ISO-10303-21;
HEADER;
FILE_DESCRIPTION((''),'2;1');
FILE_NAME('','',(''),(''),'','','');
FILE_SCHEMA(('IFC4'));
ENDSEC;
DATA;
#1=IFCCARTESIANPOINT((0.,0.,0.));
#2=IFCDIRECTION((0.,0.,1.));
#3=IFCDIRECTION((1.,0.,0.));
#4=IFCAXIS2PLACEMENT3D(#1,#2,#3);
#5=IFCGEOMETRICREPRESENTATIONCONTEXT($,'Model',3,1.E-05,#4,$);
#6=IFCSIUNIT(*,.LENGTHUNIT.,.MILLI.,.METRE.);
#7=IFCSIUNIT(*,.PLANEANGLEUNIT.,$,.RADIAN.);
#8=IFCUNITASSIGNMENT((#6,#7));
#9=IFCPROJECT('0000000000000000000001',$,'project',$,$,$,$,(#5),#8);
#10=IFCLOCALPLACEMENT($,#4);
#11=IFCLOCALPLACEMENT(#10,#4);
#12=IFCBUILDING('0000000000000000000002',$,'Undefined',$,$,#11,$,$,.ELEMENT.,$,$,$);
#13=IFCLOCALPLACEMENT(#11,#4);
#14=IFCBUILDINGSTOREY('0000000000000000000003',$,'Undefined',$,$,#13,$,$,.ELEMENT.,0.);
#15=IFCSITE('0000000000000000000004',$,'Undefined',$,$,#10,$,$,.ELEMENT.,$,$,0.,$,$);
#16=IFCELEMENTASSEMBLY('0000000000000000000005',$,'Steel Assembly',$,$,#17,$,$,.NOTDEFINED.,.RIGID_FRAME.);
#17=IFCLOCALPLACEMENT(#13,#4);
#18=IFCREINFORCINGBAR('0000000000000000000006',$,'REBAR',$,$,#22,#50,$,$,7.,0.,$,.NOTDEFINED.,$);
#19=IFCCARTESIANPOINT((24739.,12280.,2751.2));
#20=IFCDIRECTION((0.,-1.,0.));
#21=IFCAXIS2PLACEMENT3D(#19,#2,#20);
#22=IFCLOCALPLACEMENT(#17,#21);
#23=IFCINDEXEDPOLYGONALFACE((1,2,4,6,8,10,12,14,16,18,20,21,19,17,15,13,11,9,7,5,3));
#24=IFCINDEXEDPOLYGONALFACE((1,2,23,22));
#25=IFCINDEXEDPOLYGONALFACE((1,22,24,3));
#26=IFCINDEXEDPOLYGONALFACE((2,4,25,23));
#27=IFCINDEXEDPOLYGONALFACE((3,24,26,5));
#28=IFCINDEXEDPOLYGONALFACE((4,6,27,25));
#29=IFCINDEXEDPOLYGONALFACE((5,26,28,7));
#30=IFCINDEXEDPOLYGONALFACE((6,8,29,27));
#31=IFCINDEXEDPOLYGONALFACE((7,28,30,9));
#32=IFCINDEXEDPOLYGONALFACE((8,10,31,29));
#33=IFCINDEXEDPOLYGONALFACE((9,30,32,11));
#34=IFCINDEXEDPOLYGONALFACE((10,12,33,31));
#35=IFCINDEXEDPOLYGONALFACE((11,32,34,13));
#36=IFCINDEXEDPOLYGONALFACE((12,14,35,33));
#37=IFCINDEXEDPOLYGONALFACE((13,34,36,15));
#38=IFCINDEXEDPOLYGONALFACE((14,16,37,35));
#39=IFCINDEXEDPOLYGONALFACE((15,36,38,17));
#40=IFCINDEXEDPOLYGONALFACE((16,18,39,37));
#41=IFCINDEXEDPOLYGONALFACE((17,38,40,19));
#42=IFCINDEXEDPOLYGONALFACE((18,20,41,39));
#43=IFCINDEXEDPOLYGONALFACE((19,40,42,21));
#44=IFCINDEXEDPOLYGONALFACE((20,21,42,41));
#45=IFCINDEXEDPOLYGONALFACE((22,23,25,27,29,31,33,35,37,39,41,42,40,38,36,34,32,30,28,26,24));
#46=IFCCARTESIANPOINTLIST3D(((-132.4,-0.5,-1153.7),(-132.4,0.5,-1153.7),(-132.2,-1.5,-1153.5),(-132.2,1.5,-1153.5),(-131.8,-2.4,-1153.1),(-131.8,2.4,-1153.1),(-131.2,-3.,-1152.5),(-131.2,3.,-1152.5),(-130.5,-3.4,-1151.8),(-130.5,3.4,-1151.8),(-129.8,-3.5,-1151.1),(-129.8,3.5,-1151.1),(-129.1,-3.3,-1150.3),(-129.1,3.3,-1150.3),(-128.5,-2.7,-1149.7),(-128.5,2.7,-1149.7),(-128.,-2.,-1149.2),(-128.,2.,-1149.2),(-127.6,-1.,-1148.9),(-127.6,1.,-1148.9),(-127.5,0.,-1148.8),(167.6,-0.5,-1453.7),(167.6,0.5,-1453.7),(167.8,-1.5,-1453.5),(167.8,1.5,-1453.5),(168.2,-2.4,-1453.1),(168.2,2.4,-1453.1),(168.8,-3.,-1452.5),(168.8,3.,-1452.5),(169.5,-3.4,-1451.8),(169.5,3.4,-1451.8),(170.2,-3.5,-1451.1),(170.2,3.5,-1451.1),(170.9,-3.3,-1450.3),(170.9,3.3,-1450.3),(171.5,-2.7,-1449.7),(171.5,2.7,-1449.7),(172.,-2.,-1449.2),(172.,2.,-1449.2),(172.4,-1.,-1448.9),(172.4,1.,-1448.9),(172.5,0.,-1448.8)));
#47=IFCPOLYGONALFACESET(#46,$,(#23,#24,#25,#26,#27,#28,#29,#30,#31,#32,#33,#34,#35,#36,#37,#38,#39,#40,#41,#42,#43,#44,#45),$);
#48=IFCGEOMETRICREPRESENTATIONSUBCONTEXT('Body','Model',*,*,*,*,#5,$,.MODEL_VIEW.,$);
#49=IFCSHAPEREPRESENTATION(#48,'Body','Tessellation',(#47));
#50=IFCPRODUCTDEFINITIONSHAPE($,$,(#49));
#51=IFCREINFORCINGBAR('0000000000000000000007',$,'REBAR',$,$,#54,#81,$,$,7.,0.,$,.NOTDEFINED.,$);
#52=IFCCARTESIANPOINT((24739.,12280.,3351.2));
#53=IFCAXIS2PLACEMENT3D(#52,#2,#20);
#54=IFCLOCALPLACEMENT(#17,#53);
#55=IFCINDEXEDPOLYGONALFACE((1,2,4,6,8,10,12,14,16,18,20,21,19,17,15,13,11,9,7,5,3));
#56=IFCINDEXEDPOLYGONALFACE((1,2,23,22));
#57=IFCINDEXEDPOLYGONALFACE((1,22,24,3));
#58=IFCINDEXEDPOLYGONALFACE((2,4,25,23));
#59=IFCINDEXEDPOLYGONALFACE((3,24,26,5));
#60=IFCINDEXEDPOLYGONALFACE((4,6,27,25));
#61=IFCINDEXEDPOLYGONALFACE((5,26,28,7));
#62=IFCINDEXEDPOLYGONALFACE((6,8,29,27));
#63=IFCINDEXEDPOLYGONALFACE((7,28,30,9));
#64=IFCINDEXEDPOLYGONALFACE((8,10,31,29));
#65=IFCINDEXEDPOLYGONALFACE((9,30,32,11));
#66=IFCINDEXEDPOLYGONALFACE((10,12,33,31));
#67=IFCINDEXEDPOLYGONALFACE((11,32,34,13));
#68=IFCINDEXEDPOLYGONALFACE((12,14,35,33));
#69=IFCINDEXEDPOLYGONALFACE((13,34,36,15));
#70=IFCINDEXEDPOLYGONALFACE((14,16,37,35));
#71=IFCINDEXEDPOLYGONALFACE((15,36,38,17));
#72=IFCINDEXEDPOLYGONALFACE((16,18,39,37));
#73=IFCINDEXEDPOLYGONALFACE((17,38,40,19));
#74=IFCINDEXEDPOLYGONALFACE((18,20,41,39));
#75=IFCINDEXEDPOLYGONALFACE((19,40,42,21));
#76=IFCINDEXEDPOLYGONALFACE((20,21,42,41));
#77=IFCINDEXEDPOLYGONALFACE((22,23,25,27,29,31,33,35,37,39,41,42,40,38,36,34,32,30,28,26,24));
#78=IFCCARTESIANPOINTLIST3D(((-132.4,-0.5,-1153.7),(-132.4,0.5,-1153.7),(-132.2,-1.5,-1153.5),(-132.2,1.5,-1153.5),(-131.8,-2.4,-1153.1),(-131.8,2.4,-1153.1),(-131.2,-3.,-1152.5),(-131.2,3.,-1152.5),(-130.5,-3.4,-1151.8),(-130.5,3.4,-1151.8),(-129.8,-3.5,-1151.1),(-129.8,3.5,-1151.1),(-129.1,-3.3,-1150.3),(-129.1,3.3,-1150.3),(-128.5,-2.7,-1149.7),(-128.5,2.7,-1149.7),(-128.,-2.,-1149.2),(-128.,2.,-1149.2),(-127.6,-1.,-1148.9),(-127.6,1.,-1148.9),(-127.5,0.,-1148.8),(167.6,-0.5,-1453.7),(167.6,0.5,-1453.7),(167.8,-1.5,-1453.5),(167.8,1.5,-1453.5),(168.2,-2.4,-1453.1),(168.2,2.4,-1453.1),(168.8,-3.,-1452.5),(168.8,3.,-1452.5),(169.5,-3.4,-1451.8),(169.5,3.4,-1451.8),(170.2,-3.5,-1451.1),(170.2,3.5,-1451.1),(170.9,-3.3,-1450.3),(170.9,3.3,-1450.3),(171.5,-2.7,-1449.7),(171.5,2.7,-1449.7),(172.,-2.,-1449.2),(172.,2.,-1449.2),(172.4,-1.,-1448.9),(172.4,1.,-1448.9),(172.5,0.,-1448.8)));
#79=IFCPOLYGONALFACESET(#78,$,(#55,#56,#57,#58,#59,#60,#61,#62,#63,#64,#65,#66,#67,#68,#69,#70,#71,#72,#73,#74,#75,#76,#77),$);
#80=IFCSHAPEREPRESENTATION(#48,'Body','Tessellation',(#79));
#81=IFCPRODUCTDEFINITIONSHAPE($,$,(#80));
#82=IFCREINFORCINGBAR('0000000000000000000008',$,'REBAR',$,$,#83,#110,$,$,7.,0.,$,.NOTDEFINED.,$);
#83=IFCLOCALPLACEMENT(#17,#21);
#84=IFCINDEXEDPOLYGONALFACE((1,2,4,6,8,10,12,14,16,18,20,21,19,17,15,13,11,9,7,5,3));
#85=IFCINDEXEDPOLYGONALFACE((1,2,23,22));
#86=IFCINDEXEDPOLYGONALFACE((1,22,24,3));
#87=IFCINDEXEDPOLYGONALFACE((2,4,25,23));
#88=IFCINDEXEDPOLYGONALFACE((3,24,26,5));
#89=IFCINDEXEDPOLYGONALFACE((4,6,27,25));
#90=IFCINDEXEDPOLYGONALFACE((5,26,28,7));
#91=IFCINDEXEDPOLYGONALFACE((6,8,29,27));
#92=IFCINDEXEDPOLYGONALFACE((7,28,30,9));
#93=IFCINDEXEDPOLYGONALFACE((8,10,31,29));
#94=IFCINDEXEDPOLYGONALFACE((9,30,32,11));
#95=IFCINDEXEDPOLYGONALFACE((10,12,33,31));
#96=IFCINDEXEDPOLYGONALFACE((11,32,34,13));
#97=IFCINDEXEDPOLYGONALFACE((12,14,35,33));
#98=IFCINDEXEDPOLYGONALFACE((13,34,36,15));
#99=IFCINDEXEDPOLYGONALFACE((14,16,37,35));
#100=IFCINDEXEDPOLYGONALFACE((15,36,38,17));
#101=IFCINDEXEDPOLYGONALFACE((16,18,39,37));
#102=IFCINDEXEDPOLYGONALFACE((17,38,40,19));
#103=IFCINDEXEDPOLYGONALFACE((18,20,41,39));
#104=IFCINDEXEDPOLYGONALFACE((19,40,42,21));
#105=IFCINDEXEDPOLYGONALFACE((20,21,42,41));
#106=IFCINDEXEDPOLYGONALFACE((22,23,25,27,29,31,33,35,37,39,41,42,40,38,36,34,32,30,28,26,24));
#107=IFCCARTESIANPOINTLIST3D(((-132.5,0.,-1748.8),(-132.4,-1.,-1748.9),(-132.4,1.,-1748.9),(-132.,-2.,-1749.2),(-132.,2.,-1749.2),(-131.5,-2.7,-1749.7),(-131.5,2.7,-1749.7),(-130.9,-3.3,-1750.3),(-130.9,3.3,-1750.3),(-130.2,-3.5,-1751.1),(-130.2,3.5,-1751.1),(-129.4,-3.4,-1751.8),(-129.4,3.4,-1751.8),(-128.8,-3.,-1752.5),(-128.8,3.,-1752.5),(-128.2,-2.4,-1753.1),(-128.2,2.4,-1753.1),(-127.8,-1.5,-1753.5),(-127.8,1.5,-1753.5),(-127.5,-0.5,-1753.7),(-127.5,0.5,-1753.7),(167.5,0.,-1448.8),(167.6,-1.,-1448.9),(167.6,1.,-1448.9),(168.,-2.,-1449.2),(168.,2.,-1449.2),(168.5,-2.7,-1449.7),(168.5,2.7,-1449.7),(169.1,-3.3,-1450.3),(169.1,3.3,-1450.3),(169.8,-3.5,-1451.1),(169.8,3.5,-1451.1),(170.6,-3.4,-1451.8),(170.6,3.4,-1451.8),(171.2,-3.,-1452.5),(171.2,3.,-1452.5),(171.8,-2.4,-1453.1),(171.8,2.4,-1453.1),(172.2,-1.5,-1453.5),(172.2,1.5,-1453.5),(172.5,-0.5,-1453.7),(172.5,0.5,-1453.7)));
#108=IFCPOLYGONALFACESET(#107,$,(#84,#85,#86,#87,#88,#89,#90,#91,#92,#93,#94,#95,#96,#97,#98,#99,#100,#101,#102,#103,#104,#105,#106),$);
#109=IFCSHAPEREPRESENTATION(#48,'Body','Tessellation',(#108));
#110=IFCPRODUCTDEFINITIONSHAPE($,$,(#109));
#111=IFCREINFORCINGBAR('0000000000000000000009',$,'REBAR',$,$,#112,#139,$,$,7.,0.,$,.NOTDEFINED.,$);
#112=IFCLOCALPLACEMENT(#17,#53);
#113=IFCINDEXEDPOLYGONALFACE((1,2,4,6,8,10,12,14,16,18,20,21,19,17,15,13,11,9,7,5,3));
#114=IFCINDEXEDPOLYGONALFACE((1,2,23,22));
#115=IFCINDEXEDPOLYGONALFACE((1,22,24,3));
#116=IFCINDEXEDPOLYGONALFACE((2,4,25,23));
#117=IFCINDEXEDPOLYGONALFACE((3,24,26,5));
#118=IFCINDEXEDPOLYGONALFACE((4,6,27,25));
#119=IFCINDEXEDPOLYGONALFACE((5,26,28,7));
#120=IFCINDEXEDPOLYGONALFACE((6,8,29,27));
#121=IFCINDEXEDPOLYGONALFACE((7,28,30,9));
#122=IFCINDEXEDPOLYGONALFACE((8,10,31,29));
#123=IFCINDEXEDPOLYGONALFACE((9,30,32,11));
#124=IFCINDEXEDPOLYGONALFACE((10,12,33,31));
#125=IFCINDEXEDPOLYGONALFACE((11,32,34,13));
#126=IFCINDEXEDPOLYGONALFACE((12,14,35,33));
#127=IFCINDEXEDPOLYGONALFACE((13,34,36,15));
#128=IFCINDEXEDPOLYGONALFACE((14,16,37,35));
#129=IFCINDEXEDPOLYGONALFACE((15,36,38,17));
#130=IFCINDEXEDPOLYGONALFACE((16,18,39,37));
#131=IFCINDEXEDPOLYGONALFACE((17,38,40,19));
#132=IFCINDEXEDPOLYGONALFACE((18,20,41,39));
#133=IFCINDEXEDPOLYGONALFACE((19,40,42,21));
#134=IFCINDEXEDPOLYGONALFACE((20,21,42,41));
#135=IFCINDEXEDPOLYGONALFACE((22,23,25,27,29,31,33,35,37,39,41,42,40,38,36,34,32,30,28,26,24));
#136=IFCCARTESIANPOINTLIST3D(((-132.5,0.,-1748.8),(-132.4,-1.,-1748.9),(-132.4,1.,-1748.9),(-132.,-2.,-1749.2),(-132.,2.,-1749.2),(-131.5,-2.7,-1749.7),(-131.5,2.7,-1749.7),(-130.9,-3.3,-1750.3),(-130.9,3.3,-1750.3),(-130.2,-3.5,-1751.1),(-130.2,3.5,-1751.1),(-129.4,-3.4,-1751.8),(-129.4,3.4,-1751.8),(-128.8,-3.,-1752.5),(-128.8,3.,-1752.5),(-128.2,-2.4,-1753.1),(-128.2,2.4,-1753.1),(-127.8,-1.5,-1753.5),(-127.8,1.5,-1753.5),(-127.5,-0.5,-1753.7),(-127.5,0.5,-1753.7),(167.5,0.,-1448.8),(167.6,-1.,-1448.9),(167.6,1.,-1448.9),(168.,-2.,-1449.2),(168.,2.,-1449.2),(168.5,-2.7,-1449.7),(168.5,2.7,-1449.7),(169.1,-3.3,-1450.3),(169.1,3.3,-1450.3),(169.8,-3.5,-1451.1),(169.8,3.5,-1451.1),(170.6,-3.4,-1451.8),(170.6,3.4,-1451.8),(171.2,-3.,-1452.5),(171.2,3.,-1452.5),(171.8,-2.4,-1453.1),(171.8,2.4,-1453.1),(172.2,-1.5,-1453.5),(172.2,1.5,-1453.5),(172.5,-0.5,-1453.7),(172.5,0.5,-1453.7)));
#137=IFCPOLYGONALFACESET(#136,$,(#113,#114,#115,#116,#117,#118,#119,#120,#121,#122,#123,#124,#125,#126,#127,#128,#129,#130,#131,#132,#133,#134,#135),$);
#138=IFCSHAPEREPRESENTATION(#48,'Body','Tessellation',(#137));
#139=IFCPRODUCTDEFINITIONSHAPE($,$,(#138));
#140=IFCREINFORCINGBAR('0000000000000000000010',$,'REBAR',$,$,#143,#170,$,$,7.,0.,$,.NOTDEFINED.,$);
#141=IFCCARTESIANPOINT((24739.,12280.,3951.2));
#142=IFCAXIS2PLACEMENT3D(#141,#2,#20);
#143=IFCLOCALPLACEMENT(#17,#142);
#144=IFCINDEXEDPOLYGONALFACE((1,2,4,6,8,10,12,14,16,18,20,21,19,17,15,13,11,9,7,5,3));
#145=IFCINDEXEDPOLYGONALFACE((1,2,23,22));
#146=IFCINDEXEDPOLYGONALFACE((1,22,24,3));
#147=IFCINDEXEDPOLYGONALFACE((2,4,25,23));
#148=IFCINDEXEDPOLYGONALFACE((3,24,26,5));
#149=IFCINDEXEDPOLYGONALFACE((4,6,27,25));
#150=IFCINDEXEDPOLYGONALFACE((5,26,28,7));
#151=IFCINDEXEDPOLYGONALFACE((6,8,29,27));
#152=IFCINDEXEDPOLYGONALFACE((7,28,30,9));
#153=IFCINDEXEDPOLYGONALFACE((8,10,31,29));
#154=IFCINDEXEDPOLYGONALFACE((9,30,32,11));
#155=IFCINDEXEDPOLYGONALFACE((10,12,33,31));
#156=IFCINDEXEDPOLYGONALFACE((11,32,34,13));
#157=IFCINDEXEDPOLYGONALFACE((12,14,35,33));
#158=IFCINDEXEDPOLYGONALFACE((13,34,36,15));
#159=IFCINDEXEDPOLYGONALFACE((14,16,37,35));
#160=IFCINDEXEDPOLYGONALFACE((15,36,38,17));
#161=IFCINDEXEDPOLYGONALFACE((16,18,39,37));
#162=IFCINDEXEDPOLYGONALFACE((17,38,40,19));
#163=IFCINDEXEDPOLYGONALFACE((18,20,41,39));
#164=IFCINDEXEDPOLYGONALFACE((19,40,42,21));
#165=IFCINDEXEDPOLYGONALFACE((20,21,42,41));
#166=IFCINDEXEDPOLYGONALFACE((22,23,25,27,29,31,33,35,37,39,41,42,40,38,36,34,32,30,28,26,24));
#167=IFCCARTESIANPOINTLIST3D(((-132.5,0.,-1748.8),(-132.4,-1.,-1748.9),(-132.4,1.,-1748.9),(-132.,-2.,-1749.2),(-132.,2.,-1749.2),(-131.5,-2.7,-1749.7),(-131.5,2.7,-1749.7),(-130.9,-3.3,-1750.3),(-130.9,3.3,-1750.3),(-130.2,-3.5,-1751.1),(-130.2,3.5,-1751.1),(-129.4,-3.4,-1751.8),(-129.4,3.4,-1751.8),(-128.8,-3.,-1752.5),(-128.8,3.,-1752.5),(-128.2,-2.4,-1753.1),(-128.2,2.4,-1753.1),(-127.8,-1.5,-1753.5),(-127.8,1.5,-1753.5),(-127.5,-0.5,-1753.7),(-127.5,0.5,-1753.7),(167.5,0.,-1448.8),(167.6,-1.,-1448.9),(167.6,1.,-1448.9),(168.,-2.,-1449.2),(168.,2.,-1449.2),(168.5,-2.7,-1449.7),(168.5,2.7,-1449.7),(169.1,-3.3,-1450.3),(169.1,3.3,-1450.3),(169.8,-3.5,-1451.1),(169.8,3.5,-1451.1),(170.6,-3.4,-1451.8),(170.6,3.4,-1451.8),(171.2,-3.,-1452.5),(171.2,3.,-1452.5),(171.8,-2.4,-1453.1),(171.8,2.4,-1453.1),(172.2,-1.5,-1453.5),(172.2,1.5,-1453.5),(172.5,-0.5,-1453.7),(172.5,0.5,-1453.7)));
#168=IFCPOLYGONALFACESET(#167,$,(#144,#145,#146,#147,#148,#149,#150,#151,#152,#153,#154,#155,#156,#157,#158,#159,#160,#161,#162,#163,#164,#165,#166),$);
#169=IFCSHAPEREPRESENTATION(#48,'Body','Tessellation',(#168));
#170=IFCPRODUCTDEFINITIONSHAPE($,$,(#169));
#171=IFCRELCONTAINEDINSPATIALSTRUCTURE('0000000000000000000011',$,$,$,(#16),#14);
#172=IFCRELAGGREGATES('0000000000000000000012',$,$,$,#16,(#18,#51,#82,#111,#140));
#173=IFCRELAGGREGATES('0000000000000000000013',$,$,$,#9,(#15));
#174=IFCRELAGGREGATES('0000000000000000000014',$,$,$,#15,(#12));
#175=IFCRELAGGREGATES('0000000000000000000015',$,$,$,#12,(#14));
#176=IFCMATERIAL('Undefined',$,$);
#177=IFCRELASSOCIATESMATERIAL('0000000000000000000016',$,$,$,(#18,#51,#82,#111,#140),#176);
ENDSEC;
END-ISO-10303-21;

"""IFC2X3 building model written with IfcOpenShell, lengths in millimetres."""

from ifc_helpers import new_model, entity, si_unit, frame, origin_with_axes, place, context, subcontext, project, spatial, source, transform, mapped, material, element, aggregate, save


model = new_model("IFC2X3")

# Units and contexts
model_context = context("Model", 3, precision=1e-05, world=origin_with_axes())
body_context = subcontext(model_context, "Body", "Model", "MODEL_VIEW")
ifc_project = project(units=[si_unit("LENGTHUNIT", "METRE", prefix="MILLI"), si_unit("PLANEANGLEUNIT", "RADIAN")], contexts=[model_context])

# Site, building, storey
site_placement = place(None, origin_with_axes())
site = spatial("IfcSite", under=ifc_project, at=site_placement, Name="Undefined", CompositionType="ELEMENT", RefElevation=0.0)
building_placement = place(site_placement, origin_with_axes())
building = spatial("IfcBuilding", under=site, at=building_placement, Name="Undefined", CompositionType="ELEMENT")
storey_placement = place(building_placement, origin_with_axes())
storey = spatial("IfcBuildingStorey", under=building, at=storey_placement, Name="Undefined", CompositionType="ELEMENT", Elevation=0.0)

# Shared definitions
ifc_material_1 = material(Name="Undefined")

# Element assembly, reinforcing bars
assembly_1_placement = place(storey_placement, origin_with_axes())
assembly_1 = element("IfcElementAssembly", 1, at=assembly_1_placement, inside=storey, Name="Steel Assembly", AssemblyPlace="NOTDEFINED", PredefinedType="RIGID_FRAME")
shared_shape_1 = source(origin_with_axes(), body_context, "Body", "AdvancedSweptSolid", [
    entity("IfcSweptDiskSolid", entity("IfcTrimmedCurve", entity("IfcLine", entity("IfcCartesianPoint", [0.0, 0.0, 0.0]), entity("IfcVector", entity("IfcDirection", [0.707107, 0.0, -0.707107]), 1.0)), [entity("IfcParameterValue", 0.0)], [entity("IfcParameterValue", 424.264069)], True, "PARAMETER"), 3.5, None, 0.0, 424.3),
])
reinforcing_bar_1_placement = place(assembly_1_placement, frame((24739.0, 12280.0, 2751.2), z_axis=(0.0, 0.0, 1.0), x_axis=(0.0, -1.0, 0.0)))
reinforcing_bar_1 = element("IfcReinforcingBar", 2, at=reinforcing_bar_1_placement, material=ifc_material_1, Name="REBAR", BarRole="NOTDEFINED", CrossSectionArea=0.0, NominalDiameter=7.0, context=body_context, shape_type="MappedRepresentation", body=[
    mapped(shared_shape_1, transform((-130.0, 0.0, -1151.2))),
])
shared_shape_2 = source(origin_with_axes(), body_context, "Body", "AdvancedSweptSolid", [
    entity("IfcSweptDiskSolid", entity("IfcTrimmedCurve", entity("IfcLine", entity("IfcCartesianPoint", [0.0, 0.0, 0.0]), entity("IfcVector", entity("IfcDirection", [0.707107, 0.0, -0.707107]), 1.0)), [entity("IfcParameterValue", 0.0)], [entity("IfcParameterValue", 424.264069)], True, "PARAMETER"), 3.5, None, 0.0, 424.3),
])
reinforcing_bar_2_placement = place(assembly_1_placement, frame((24739.0, 12280.0, 3351.2), z_axis=(0.0, 0.0, 1.0), x_axis=(0.0, -1.0, 0.0)))
reinforcing_bar_2 = element("IfcReinforcingBar", 3, at=reinforcing_bar_2_placement, material=ifc_material_1, Name="REBAR", BarRole="NOTDEFINED", CrossSectionArea=0.0, NominalDiameter=7.0, context=body_context, shape_type="MappedRepresentation", body=[
    mapped(shared_shape_2, transform((-130.0, 0.0, -1151.2))),
])
shared_shape_3 = source(origin_with_axes(), body_context, "Body", "AdvancedSweptSolid", [
    entity("IfcSweptDiskSolid", entity("IfcTrimmedCurve", entity("IfcLine", entity("IfcCartesianPoint", [0.0, 0.0, 0.0]), entity("IfcVector", entity("IfcDirection", [0.707107, 0.0, 0.707107]), 1.0)), [entity("IfcParameterValue", 0.0)], [entity("IfcParameterValue", 424.264069)], True, "PARAMETER"), 3.5, None, 0.0, 424.3),
])
reinforcing_bar_3_placement = place(assembly_1_placement, frame((24739.0, 12280.0, 2751.2), z_axis=(0.0, 0.0, 1.0), x_axis=(0.0, -1.0, 0.0)))
reinforcing_bar_3 = element("IfcReinforcingBar", 4, at=reinforcing_bar_3_placement, material=ifc_material_1, Name="REBAR", BarRole="NOTDEFINED", CrossSectionArea=0.0, NominalDiameter=7.0, context=body_context, shape_type="MappedRepresentation", body=[
    mapped(shared_shape_3, transform((-130.0, 0.0, -1751.2))),
])
shared_shape_4 = source(origin_with_axes(), body_context, "Body", "AdvancedSweptSolid", [
    entity("IfcSweptDiskSolid", entity("IfcTrimmedCurve", entity("IfcLine", entity("IfcCartesianPoint", [0.0, 0.0, 0.0]), entity("IfcVector", entity("IfcDirection", [0.707107, 0.0, 0.707107]), 1.0)), [entity("IfcParameterValue", 0.0)], [entity("IfcParameterValue", 424.264069)], True, "PARAMETER"), 3.5, None, 0.0, 424.3),
])
reinforcing_bar_4_placement = place(assembly_1_placement, frame((24739.0, 12280.0, 3351.2), z_axis=(0.0, 0.0, 1.0), x_axis=(0.0, -1.0, 0.0)))
reinforcing_bar_4 = element("IfcReinforcingBar", 5, at=reinforcing_bar_4_placement, material=ifc_material_1, Name="REBAR", BarRole="NOTDEFINED", CrossSectionArea=0.0, NominalDiameter=7.0, context=body_context, shape_type="MappedRepresentation", body=[
    mapped(shared_shape_4, transform((-130.0, 0.0, -1751.2))),
])
shared_shape_5 = source(origin_with_axes(), body_context, "Body", "AdvancedSweptSolid", [
    entity("IfcSweptDiskSolid", entity("IfcTrimmedCurve", entity("IfcLine", entity("IfcCartesianPoint", [0.0, 0.0, 0.0]), entity("IfcVector", entity("IfcDirection", [0.707107, 0.0, 0.707107]), 1.0)), [entity("IfcParameterValue", 0.0)], [entity("IfcParameterValue", 424.264069)], True, "PARAMETER"), 3.5, None, 0.0, 424.3),
])
reinforcing_bar_5_placement = place(assembly_1_placement, frame((24739.0, 12280.0, 3951.2), z_axis=(0.0, 0.0, 1.0), x_axis=(0.0, -1.0, 0.0)))
reinforcing_bar_5 = element("IfcReinforcingBar", 6, at=reinforcing_bar_5_placement, material=ifc_material_1, Name="REBAR", BarRole="NOTDEFINED", CrossSectionArea=0.0, NominalDiameter=7.0, context=body_context, shape_type="MappedRepresentation", body=[
    mapped(shared_shape_5, transform((-130.0, 0.0, -1751.2))),
])
aggregate(assembly_1, [reinforcing_bar_1, reinforcing_bar_2, reinforcing_bar_3, reinforcing_bar_4, reinforcing_bar_5])

save(model, "model.ifc")
